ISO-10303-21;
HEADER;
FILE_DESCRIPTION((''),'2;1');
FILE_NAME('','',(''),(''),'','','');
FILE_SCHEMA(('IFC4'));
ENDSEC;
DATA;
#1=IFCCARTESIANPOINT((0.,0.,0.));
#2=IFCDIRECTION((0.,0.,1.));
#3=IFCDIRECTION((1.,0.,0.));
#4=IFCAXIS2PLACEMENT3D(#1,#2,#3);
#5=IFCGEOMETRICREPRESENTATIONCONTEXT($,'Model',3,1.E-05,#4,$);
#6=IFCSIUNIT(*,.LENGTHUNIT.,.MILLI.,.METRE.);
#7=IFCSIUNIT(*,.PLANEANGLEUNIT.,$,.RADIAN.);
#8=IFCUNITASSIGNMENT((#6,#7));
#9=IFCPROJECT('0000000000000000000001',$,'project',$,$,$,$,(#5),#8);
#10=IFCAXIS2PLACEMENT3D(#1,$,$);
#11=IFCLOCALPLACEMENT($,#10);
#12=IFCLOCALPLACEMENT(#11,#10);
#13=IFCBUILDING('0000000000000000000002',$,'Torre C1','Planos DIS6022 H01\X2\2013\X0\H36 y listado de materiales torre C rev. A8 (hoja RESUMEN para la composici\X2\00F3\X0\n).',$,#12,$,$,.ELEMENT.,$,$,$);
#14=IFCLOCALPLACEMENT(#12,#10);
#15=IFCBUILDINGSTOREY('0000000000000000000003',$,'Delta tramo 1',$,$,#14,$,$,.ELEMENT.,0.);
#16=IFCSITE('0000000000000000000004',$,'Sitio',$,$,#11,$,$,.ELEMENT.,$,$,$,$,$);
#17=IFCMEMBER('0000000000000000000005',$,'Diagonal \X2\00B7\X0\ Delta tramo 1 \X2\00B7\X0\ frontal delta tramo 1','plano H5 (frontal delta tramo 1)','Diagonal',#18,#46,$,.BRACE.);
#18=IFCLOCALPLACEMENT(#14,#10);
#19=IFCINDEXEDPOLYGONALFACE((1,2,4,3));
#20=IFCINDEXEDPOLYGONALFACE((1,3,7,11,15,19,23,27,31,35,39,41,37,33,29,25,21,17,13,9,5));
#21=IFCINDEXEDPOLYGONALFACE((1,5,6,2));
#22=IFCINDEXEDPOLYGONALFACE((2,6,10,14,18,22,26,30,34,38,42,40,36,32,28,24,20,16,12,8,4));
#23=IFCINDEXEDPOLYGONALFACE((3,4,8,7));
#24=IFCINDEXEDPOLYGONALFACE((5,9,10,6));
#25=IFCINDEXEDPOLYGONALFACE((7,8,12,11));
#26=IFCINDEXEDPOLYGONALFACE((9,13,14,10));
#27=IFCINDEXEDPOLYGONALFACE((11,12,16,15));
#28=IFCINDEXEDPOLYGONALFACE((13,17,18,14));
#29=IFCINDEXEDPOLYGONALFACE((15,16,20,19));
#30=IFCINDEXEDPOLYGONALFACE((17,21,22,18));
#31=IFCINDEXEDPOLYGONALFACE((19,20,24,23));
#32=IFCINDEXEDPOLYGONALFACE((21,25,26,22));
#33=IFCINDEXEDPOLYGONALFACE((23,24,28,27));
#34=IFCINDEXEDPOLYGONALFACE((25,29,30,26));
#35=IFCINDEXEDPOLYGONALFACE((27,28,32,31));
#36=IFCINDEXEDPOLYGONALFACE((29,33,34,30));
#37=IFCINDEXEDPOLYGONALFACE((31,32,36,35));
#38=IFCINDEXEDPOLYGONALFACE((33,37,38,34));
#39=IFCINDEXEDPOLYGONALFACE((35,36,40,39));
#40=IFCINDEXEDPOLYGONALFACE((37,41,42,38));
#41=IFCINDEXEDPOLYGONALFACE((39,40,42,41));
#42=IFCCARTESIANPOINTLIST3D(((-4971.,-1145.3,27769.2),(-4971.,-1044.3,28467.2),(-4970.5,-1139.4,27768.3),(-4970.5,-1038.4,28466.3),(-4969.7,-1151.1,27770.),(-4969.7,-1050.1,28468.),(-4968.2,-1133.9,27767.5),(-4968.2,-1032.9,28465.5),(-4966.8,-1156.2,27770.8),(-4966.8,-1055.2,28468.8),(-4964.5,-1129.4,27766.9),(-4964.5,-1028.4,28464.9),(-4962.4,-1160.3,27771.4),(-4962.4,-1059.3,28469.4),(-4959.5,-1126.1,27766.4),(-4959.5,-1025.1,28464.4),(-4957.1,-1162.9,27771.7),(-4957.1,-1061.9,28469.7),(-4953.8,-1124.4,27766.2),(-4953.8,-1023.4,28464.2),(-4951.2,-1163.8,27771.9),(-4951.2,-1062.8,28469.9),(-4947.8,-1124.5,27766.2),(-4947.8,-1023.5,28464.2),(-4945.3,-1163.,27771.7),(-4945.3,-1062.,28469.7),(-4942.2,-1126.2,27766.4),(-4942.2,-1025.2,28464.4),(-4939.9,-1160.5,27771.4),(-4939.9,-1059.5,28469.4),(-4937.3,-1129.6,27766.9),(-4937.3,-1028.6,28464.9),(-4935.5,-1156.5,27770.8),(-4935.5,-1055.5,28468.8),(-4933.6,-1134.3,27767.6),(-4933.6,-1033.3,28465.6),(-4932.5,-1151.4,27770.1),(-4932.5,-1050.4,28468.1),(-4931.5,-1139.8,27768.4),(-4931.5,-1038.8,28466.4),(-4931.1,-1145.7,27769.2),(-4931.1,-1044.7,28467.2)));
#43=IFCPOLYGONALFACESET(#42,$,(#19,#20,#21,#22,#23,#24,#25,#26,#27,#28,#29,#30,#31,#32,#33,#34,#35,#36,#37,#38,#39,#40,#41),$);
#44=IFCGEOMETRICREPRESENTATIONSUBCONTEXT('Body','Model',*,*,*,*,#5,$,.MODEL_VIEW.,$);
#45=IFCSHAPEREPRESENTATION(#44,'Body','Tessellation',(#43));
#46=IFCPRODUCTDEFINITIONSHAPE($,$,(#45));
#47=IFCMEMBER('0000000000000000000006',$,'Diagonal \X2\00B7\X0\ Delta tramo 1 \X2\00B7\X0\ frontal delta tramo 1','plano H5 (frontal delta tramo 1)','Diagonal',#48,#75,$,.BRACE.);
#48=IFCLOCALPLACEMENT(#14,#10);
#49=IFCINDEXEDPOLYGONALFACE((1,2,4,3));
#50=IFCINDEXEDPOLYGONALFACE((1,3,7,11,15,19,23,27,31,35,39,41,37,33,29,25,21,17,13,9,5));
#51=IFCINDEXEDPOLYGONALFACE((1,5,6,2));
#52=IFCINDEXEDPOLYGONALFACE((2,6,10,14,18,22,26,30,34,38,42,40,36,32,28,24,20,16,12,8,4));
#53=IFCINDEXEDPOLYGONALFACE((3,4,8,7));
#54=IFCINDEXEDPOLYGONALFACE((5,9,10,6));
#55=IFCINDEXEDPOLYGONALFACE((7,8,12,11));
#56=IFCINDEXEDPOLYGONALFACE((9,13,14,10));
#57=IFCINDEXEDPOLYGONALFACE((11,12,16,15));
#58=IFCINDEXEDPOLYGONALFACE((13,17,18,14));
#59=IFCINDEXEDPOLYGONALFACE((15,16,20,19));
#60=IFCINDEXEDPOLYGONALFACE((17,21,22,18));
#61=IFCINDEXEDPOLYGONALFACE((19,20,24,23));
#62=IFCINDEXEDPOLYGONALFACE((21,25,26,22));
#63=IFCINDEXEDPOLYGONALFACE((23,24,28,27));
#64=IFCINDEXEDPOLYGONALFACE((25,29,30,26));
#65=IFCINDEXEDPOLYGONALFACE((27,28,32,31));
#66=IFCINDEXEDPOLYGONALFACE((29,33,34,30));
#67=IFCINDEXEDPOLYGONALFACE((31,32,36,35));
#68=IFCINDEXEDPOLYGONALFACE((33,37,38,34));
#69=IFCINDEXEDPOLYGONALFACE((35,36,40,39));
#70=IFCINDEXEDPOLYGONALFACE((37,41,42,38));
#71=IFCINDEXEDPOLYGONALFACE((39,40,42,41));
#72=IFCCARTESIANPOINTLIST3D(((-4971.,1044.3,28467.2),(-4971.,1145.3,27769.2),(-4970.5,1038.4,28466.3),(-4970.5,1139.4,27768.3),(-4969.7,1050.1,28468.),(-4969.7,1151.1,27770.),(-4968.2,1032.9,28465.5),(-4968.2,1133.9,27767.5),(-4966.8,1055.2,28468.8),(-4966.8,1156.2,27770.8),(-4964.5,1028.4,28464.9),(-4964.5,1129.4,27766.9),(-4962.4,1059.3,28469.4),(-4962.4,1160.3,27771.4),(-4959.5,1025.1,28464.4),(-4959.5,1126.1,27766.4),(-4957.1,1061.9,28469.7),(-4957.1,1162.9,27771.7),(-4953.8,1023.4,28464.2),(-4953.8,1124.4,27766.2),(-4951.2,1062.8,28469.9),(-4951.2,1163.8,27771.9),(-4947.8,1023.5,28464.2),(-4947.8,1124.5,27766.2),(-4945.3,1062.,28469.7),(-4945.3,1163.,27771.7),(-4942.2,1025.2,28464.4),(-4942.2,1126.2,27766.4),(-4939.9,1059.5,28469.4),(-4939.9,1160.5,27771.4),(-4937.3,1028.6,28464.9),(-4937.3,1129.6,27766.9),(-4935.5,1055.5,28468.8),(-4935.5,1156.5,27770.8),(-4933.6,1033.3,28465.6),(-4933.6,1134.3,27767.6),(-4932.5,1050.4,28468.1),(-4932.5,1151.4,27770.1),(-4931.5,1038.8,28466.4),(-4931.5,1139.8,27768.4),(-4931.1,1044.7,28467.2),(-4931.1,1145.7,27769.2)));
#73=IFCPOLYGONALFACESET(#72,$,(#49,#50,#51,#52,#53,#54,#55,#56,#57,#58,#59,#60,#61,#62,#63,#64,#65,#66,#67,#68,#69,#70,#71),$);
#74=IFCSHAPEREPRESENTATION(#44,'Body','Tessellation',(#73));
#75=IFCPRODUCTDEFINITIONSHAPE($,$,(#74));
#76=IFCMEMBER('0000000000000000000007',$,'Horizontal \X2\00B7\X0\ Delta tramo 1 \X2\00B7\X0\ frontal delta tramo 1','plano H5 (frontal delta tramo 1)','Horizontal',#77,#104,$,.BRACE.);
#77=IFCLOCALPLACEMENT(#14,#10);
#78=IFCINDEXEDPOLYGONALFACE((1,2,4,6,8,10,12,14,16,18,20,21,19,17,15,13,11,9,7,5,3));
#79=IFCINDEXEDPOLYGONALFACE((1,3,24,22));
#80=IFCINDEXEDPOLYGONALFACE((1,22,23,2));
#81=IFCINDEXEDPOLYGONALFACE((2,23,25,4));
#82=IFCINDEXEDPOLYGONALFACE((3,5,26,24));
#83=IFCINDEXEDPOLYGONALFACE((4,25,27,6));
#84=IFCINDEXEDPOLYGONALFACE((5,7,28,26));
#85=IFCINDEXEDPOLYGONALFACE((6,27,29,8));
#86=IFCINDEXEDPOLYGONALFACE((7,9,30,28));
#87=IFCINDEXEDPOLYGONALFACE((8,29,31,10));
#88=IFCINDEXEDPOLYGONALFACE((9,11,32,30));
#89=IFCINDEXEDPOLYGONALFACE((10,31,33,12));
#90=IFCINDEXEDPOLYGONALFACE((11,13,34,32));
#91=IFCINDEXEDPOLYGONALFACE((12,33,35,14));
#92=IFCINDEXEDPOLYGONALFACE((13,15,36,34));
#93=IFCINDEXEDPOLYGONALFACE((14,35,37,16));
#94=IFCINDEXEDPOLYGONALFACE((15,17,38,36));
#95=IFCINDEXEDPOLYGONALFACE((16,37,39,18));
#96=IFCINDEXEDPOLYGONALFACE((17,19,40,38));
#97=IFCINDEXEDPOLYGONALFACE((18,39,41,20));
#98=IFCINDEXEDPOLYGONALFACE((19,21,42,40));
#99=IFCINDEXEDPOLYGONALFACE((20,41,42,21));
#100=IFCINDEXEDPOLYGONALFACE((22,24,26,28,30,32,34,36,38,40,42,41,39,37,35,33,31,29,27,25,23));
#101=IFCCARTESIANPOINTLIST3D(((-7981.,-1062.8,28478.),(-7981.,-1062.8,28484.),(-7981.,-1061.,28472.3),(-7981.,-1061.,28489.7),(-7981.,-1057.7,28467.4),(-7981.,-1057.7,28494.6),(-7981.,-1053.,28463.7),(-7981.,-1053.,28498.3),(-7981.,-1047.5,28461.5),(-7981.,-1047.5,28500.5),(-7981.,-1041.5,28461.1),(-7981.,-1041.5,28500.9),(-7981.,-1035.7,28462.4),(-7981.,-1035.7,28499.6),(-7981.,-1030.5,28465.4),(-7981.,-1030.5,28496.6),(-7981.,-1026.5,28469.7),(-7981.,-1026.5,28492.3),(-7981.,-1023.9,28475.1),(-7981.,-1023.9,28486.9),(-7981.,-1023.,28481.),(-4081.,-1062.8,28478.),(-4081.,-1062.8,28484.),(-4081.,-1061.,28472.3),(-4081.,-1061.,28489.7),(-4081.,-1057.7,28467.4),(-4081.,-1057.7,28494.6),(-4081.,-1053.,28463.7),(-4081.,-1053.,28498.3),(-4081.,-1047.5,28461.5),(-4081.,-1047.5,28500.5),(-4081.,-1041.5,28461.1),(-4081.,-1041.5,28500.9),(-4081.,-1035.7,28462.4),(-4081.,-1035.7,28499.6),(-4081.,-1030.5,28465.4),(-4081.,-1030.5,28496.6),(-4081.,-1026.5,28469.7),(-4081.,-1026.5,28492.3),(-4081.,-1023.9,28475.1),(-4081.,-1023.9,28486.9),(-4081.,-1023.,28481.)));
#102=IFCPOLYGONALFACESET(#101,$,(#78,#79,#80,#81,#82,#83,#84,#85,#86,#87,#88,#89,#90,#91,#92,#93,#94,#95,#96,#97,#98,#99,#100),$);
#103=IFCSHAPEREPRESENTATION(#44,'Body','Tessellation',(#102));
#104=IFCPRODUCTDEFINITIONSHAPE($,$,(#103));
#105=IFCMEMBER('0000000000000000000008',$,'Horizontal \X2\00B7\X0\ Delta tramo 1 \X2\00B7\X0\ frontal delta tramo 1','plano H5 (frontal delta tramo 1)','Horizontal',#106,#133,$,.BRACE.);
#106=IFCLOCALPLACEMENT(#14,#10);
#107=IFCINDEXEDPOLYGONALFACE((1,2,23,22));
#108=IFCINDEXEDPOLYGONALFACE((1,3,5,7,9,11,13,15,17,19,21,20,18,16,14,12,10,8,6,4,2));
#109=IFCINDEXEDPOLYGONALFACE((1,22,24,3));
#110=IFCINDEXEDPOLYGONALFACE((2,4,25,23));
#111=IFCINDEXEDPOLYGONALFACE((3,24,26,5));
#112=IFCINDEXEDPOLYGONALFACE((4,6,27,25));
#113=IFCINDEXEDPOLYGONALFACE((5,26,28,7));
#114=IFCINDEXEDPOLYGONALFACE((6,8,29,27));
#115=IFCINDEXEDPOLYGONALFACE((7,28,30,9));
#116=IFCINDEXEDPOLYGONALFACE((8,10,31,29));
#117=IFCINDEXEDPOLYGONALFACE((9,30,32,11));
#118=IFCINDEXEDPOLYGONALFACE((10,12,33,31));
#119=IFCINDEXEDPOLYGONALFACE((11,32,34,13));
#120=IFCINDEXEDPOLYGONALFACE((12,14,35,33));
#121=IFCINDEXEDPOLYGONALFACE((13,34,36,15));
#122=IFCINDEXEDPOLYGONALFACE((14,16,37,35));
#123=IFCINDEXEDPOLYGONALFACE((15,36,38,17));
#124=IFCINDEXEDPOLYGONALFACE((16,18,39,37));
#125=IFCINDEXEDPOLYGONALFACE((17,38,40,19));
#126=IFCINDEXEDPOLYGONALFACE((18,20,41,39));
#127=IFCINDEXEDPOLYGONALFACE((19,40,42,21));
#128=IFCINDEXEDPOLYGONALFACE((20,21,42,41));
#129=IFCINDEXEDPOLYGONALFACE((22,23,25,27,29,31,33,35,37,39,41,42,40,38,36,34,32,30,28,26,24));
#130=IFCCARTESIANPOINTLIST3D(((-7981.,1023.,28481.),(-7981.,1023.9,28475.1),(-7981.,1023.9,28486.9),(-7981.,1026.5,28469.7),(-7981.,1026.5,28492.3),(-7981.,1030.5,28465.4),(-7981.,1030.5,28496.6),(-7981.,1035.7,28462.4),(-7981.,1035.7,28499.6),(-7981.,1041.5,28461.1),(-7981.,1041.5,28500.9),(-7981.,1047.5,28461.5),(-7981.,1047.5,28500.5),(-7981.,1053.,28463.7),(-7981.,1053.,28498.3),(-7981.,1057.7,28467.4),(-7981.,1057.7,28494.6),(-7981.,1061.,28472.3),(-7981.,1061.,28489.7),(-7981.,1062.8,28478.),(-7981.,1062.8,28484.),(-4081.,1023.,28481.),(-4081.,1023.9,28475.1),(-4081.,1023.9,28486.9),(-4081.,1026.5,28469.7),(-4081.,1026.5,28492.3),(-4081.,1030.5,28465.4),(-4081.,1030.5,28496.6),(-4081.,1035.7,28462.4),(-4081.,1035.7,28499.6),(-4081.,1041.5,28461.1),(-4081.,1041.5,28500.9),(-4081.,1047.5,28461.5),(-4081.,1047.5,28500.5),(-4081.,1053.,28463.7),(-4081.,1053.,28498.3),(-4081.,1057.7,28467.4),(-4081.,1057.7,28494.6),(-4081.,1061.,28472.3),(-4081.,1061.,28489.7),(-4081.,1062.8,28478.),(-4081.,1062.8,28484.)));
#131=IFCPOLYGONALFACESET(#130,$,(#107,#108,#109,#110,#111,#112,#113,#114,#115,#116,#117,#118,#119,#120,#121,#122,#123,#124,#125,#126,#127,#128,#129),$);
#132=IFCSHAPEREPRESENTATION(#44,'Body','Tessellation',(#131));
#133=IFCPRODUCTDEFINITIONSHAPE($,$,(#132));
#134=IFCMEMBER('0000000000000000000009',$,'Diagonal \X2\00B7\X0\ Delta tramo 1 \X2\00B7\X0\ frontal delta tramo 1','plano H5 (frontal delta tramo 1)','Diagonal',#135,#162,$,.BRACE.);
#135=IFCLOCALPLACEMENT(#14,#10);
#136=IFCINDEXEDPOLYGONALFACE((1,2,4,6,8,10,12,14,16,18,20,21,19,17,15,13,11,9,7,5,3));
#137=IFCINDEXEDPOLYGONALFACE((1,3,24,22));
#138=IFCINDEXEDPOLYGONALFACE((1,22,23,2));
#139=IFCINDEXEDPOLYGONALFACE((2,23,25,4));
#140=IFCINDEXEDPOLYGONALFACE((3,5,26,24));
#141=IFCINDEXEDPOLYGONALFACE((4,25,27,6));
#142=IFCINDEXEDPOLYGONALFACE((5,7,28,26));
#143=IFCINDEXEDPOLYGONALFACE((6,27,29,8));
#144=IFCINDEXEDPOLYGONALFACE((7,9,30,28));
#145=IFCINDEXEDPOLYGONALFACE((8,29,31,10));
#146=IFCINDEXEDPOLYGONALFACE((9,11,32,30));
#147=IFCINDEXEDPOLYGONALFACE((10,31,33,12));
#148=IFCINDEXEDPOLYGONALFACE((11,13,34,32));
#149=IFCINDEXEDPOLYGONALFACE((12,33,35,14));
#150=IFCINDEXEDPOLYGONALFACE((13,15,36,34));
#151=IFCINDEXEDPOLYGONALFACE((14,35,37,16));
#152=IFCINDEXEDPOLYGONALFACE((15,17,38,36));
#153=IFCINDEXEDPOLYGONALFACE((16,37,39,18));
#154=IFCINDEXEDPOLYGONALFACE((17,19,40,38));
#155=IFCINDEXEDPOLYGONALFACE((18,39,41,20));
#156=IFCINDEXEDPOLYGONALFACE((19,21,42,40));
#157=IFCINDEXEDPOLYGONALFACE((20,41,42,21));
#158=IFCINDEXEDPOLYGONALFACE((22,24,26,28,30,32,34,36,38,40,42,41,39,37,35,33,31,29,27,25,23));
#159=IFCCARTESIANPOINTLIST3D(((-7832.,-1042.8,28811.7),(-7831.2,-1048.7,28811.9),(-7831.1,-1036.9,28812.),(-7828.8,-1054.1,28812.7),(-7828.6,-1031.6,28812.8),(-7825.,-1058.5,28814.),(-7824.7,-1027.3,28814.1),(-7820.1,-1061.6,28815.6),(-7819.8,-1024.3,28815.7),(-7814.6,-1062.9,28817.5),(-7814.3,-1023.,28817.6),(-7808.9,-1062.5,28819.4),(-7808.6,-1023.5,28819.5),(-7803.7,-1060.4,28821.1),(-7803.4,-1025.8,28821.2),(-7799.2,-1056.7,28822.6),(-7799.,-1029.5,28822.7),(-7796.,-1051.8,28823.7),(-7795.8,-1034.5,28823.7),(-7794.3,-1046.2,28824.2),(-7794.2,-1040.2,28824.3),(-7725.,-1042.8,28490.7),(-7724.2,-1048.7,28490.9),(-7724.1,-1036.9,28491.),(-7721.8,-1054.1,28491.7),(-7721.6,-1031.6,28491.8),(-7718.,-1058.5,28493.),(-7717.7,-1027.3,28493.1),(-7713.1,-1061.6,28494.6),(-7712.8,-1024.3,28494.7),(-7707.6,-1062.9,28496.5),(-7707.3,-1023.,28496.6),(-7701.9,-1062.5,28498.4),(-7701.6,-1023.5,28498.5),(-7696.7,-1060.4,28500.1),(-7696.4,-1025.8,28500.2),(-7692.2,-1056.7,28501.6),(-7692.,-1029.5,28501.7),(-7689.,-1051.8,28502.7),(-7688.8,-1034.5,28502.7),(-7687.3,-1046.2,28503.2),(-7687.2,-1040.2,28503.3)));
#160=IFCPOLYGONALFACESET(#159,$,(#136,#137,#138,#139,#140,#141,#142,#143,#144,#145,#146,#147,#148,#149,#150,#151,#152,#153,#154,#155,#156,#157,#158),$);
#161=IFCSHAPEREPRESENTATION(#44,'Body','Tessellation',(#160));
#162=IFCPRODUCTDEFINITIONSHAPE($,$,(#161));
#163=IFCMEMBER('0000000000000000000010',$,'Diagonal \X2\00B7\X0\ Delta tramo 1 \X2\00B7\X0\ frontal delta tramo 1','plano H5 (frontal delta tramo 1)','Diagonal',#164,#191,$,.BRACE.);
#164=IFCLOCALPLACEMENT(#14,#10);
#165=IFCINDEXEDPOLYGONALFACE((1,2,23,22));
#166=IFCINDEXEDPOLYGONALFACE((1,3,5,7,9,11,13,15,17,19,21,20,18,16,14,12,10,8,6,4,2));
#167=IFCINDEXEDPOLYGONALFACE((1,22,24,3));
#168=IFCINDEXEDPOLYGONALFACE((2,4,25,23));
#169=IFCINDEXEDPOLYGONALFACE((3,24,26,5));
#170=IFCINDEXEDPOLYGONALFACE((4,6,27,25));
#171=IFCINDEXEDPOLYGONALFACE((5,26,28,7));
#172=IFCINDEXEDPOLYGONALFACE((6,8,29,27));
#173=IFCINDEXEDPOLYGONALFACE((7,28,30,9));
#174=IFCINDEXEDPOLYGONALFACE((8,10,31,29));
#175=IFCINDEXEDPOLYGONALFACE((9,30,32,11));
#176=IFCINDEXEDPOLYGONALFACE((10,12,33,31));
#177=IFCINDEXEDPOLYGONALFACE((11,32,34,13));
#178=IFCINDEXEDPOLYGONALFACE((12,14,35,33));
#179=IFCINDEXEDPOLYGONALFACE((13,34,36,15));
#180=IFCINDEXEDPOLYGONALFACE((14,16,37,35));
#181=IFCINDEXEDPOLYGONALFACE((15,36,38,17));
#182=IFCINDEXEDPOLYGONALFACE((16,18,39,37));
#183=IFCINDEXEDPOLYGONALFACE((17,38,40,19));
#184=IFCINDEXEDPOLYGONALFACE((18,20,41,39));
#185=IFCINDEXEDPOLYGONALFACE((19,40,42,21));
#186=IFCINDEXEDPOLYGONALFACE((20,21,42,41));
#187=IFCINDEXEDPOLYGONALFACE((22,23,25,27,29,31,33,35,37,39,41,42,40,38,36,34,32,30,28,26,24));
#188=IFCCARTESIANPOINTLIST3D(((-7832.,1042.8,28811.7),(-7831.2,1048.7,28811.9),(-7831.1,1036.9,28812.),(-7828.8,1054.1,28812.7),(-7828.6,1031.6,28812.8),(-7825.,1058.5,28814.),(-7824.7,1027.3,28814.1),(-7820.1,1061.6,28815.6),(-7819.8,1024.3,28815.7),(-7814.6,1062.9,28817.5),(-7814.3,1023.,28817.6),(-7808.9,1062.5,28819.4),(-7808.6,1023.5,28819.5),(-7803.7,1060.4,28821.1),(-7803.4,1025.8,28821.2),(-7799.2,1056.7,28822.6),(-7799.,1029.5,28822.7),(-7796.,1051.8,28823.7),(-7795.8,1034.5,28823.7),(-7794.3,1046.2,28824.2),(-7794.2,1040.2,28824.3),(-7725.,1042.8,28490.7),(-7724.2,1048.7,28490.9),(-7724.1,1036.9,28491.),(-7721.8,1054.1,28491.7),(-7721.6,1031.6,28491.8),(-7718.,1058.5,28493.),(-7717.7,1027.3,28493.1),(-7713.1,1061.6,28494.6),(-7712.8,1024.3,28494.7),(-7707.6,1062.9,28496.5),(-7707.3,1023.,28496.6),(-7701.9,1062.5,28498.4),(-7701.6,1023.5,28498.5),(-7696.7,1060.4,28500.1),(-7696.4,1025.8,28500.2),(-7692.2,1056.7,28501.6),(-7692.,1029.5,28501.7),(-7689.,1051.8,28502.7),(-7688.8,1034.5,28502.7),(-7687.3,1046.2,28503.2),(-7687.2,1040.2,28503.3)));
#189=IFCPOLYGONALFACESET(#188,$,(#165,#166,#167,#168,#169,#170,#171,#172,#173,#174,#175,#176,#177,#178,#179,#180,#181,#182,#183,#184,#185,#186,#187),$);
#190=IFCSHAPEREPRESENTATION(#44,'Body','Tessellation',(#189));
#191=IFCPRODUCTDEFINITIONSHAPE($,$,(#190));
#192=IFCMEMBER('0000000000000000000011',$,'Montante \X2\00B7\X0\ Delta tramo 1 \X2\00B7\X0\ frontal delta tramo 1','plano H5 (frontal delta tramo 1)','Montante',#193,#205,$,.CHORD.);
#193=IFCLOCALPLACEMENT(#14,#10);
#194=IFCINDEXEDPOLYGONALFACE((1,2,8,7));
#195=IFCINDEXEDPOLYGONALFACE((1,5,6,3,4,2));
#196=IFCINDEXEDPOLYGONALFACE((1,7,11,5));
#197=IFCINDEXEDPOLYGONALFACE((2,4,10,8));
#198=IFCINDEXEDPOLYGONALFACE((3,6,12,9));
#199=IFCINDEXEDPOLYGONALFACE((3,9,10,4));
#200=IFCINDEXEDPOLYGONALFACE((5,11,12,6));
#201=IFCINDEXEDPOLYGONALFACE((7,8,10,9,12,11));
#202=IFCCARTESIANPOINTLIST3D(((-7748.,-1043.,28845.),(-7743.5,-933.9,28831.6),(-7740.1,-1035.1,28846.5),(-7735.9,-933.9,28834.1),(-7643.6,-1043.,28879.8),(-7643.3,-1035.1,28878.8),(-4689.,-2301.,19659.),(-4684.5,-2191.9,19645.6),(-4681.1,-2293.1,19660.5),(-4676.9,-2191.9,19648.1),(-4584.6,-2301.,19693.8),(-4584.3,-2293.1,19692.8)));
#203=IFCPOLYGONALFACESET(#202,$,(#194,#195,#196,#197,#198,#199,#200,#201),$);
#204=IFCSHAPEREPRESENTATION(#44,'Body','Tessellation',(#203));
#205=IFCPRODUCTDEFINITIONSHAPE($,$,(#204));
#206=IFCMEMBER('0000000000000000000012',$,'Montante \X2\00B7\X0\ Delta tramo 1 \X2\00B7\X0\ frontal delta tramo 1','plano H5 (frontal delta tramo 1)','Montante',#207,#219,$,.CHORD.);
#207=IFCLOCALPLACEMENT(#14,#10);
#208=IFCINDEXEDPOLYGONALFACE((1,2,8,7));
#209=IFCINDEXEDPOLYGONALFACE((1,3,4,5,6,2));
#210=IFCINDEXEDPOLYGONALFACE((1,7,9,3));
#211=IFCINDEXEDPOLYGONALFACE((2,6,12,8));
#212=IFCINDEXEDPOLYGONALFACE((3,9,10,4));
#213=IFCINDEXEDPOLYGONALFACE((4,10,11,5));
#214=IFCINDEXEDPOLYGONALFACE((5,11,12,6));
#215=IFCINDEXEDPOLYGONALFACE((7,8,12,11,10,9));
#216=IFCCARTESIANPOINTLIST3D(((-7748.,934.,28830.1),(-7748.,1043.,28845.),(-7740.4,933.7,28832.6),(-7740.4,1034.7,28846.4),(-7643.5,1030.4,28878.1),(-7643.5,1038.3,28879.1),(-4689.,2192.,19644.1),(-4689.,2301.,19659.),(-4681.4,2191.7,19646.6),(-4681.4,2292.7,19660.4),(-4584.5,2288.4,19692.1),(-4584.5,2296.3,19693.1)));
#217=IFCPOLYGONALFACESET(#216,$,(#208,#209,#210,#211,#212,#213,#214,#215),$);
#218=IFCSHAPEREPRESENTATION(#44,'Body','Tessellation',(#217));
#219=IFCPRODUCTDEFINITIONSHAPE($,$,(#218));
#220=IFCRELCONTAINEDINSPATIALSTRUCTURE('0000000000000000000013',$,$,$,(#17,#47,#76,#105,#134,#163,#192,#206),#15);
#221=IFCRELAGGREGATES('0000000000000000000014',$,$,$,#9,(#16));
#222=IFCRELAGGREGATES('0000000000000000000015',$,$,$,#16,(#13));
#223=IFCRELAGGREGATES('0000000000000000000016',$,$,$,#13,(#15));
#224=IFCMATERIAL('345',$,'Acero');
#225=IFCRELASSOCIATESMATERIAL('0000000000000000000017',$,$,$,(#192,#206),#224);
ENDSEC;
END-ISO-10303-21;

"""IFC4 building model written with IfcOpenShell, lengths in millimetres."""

from ifc_helpers import new_model, si_unit, frame, frame_2d, origin, origin_with_axes, place, context, subcontext, project, spatial, circle, l_section, extrude, material, element, save


model = new_model("IFC4")

# Units and contexts
model_context = context("Model", 3, precision=1e-05, world=origin_with_axes())
body_context = subcontext(model_context, "Body", "Model", "MODEL_VIEW")
ifc_project = project(units=[si_unit("LENGTHUNIT", "METRE", prefix="MILLI"), si_unit("PLANEANGLEUNIT", "RADIAN")], contexts=[model_context])

# Site, building, storey
site_placement = place(None, origin())
site = spatial("IfcSite", under=ifc_project, at=site_placement, Name="Sitio", CompositionType="ELEMENT")
building_placement = place(site_placement, origin())
building = spatial("IfcBuilding", under=site, at=building_placement, Name="Torre C1", Description="Planos DIS6022 H01–H36 y listado de materiales torre C rev. A8 (hoja RESUMEN para la composición).", CompositionType="ELEMENT")
storey_placement = place(building_placement, origin())
storey = spatial("IfcBuildingStorey", under=building, at=storey_placement, Name="Delta tramo 1", CompositionType="ELEMENT", Elevation=0.0)

# Members
for number, where, z_axis, x_axis, name in (
    (1, (-4951.0, -1144.0, 27769.0), (0.0, 0.143208, 0.989693), (0.976933, 0.211345, -0.030581), "Diagonal · Delta tramo 1 · frontal delta tramo 1"),
    (2, (-4951.0, 1144.0, 27769.0), (0.0, -0.143208, 0.989693), (0.976933, -0.211345, -0.030581), "Diagonal · Delta tramo 1 · frontal delta tramo 1"),
):
    element("IfcMember", number, at=place(storey_placement, frame(where, z_axis=z_axis, x_axis=x_axis)), inside=storey, Name=name, Description="plano H5 (frontal delta tramo 1)", ObjectType="Diagonal", PredefinedType="BRACE", context=body_context, shape_type="SweptSolid", body=[
        extrude(circle(Radius=20.0), None, (0.0, 0.0, 1.0), 705.3),
    ])
for number, where, z_axis, x_axis, name in (
    (3, (-4081.0, -1043.0, 28481.0), (-1.0, 0.0, 0.0), (0.0, 1.0, 0.0), "Horizontal · Delta tramo 1 · frontal delta tramo 1"),
    (4, (-4081.0, 1043.0, 28481.0), (-1.0, 0.0, 0.0), (0.0, -1.0, 0.0), "Horizontal · Delta tramo 1 · frontal delta tramo 1"),
):
    element("IfcMember", number, at=place(storey_placement, frame(where, z_axis=z_axis, x_axis=x_axis)), inside=storey, Name=name, Description="plano H5 (frontal delta tramo 1)", ObjectType="Horizontal", PredefinedType="BRACE", context=body_context, shape_type="SweptSolid", body=[
        extrude(circle(Radius=20.0), None, (0.0, 0.0, 1.0), 3900.0),
    ])
for number, where, z_axis, x_axis, name in (
    (5, (-7706.0, -1043.0, 28497.0), (-0.316228, 0.0, 0.948683), (0.939302, 0.140286, 0.313101), "Diagonal · Delta tramo 1 · frontal delta tramo 1"),
    (6, (-7706.0, 1043.0, 28497.0), (-0.316228, 0.0, 0.948683), (0.939302, -0.140286, 0.313101), "Diagonal · Delta tramo 1 · frontal delta tramo 1"),
):
    element("IfcMember", number, at=place(storey_placement, frame(where, z_axis=z_axis, x_axis=x_axis)), inside=storey, Name=name, Description="plano H5 (frontal delta tramo 1)", ObjectType="Diagonal", PredefinedType="BRACE", context=body_context, shape_type="SweptSolid", body=[
        extrude(circle(Radius=20.0), None, (0.0, 0.0, 1.0), 338.4),
    ])
ifc_material = material(Name="345", Category="Acero")
for number, where, z_axis, x_axis, name in (
    (7, (-7748.0, -1043.0, 28845.0), (0.313315, -0.128849, -0.940867), (0.04071, 0.991664, -0.122249), "Montante · Delta tramo 1 · frontal delta tramo 1"),
    (8, (-7748.0, 1043.0, 28845.0), (0.313315, 0.128849, -0.940867), (0.949649, -0.042511, 0.310418), "Montante · Delta tramo 1 · frontal delta tramo 1"),
):
    element("IfcMember", number, at=place(storey_placement, frame(where, z_axis=z_axis, x_axis=x_axis)), inside=storey, material=ifc_material, Name=name, Description="plano H5 (frontal delta tramo 1)", ObjectType="Montante", PredefinedType="CHORD", context=body_context, shape_type="SweptSolid", body=[
        extrude(l_section(Depth=110.0, Width=110.0, Thickness=8.0, at=frame_2d((55.0, 55.0))), None, (0.0, 0.0, 1.0), 9763.3),
    ])

save(model, "model.ifc")
